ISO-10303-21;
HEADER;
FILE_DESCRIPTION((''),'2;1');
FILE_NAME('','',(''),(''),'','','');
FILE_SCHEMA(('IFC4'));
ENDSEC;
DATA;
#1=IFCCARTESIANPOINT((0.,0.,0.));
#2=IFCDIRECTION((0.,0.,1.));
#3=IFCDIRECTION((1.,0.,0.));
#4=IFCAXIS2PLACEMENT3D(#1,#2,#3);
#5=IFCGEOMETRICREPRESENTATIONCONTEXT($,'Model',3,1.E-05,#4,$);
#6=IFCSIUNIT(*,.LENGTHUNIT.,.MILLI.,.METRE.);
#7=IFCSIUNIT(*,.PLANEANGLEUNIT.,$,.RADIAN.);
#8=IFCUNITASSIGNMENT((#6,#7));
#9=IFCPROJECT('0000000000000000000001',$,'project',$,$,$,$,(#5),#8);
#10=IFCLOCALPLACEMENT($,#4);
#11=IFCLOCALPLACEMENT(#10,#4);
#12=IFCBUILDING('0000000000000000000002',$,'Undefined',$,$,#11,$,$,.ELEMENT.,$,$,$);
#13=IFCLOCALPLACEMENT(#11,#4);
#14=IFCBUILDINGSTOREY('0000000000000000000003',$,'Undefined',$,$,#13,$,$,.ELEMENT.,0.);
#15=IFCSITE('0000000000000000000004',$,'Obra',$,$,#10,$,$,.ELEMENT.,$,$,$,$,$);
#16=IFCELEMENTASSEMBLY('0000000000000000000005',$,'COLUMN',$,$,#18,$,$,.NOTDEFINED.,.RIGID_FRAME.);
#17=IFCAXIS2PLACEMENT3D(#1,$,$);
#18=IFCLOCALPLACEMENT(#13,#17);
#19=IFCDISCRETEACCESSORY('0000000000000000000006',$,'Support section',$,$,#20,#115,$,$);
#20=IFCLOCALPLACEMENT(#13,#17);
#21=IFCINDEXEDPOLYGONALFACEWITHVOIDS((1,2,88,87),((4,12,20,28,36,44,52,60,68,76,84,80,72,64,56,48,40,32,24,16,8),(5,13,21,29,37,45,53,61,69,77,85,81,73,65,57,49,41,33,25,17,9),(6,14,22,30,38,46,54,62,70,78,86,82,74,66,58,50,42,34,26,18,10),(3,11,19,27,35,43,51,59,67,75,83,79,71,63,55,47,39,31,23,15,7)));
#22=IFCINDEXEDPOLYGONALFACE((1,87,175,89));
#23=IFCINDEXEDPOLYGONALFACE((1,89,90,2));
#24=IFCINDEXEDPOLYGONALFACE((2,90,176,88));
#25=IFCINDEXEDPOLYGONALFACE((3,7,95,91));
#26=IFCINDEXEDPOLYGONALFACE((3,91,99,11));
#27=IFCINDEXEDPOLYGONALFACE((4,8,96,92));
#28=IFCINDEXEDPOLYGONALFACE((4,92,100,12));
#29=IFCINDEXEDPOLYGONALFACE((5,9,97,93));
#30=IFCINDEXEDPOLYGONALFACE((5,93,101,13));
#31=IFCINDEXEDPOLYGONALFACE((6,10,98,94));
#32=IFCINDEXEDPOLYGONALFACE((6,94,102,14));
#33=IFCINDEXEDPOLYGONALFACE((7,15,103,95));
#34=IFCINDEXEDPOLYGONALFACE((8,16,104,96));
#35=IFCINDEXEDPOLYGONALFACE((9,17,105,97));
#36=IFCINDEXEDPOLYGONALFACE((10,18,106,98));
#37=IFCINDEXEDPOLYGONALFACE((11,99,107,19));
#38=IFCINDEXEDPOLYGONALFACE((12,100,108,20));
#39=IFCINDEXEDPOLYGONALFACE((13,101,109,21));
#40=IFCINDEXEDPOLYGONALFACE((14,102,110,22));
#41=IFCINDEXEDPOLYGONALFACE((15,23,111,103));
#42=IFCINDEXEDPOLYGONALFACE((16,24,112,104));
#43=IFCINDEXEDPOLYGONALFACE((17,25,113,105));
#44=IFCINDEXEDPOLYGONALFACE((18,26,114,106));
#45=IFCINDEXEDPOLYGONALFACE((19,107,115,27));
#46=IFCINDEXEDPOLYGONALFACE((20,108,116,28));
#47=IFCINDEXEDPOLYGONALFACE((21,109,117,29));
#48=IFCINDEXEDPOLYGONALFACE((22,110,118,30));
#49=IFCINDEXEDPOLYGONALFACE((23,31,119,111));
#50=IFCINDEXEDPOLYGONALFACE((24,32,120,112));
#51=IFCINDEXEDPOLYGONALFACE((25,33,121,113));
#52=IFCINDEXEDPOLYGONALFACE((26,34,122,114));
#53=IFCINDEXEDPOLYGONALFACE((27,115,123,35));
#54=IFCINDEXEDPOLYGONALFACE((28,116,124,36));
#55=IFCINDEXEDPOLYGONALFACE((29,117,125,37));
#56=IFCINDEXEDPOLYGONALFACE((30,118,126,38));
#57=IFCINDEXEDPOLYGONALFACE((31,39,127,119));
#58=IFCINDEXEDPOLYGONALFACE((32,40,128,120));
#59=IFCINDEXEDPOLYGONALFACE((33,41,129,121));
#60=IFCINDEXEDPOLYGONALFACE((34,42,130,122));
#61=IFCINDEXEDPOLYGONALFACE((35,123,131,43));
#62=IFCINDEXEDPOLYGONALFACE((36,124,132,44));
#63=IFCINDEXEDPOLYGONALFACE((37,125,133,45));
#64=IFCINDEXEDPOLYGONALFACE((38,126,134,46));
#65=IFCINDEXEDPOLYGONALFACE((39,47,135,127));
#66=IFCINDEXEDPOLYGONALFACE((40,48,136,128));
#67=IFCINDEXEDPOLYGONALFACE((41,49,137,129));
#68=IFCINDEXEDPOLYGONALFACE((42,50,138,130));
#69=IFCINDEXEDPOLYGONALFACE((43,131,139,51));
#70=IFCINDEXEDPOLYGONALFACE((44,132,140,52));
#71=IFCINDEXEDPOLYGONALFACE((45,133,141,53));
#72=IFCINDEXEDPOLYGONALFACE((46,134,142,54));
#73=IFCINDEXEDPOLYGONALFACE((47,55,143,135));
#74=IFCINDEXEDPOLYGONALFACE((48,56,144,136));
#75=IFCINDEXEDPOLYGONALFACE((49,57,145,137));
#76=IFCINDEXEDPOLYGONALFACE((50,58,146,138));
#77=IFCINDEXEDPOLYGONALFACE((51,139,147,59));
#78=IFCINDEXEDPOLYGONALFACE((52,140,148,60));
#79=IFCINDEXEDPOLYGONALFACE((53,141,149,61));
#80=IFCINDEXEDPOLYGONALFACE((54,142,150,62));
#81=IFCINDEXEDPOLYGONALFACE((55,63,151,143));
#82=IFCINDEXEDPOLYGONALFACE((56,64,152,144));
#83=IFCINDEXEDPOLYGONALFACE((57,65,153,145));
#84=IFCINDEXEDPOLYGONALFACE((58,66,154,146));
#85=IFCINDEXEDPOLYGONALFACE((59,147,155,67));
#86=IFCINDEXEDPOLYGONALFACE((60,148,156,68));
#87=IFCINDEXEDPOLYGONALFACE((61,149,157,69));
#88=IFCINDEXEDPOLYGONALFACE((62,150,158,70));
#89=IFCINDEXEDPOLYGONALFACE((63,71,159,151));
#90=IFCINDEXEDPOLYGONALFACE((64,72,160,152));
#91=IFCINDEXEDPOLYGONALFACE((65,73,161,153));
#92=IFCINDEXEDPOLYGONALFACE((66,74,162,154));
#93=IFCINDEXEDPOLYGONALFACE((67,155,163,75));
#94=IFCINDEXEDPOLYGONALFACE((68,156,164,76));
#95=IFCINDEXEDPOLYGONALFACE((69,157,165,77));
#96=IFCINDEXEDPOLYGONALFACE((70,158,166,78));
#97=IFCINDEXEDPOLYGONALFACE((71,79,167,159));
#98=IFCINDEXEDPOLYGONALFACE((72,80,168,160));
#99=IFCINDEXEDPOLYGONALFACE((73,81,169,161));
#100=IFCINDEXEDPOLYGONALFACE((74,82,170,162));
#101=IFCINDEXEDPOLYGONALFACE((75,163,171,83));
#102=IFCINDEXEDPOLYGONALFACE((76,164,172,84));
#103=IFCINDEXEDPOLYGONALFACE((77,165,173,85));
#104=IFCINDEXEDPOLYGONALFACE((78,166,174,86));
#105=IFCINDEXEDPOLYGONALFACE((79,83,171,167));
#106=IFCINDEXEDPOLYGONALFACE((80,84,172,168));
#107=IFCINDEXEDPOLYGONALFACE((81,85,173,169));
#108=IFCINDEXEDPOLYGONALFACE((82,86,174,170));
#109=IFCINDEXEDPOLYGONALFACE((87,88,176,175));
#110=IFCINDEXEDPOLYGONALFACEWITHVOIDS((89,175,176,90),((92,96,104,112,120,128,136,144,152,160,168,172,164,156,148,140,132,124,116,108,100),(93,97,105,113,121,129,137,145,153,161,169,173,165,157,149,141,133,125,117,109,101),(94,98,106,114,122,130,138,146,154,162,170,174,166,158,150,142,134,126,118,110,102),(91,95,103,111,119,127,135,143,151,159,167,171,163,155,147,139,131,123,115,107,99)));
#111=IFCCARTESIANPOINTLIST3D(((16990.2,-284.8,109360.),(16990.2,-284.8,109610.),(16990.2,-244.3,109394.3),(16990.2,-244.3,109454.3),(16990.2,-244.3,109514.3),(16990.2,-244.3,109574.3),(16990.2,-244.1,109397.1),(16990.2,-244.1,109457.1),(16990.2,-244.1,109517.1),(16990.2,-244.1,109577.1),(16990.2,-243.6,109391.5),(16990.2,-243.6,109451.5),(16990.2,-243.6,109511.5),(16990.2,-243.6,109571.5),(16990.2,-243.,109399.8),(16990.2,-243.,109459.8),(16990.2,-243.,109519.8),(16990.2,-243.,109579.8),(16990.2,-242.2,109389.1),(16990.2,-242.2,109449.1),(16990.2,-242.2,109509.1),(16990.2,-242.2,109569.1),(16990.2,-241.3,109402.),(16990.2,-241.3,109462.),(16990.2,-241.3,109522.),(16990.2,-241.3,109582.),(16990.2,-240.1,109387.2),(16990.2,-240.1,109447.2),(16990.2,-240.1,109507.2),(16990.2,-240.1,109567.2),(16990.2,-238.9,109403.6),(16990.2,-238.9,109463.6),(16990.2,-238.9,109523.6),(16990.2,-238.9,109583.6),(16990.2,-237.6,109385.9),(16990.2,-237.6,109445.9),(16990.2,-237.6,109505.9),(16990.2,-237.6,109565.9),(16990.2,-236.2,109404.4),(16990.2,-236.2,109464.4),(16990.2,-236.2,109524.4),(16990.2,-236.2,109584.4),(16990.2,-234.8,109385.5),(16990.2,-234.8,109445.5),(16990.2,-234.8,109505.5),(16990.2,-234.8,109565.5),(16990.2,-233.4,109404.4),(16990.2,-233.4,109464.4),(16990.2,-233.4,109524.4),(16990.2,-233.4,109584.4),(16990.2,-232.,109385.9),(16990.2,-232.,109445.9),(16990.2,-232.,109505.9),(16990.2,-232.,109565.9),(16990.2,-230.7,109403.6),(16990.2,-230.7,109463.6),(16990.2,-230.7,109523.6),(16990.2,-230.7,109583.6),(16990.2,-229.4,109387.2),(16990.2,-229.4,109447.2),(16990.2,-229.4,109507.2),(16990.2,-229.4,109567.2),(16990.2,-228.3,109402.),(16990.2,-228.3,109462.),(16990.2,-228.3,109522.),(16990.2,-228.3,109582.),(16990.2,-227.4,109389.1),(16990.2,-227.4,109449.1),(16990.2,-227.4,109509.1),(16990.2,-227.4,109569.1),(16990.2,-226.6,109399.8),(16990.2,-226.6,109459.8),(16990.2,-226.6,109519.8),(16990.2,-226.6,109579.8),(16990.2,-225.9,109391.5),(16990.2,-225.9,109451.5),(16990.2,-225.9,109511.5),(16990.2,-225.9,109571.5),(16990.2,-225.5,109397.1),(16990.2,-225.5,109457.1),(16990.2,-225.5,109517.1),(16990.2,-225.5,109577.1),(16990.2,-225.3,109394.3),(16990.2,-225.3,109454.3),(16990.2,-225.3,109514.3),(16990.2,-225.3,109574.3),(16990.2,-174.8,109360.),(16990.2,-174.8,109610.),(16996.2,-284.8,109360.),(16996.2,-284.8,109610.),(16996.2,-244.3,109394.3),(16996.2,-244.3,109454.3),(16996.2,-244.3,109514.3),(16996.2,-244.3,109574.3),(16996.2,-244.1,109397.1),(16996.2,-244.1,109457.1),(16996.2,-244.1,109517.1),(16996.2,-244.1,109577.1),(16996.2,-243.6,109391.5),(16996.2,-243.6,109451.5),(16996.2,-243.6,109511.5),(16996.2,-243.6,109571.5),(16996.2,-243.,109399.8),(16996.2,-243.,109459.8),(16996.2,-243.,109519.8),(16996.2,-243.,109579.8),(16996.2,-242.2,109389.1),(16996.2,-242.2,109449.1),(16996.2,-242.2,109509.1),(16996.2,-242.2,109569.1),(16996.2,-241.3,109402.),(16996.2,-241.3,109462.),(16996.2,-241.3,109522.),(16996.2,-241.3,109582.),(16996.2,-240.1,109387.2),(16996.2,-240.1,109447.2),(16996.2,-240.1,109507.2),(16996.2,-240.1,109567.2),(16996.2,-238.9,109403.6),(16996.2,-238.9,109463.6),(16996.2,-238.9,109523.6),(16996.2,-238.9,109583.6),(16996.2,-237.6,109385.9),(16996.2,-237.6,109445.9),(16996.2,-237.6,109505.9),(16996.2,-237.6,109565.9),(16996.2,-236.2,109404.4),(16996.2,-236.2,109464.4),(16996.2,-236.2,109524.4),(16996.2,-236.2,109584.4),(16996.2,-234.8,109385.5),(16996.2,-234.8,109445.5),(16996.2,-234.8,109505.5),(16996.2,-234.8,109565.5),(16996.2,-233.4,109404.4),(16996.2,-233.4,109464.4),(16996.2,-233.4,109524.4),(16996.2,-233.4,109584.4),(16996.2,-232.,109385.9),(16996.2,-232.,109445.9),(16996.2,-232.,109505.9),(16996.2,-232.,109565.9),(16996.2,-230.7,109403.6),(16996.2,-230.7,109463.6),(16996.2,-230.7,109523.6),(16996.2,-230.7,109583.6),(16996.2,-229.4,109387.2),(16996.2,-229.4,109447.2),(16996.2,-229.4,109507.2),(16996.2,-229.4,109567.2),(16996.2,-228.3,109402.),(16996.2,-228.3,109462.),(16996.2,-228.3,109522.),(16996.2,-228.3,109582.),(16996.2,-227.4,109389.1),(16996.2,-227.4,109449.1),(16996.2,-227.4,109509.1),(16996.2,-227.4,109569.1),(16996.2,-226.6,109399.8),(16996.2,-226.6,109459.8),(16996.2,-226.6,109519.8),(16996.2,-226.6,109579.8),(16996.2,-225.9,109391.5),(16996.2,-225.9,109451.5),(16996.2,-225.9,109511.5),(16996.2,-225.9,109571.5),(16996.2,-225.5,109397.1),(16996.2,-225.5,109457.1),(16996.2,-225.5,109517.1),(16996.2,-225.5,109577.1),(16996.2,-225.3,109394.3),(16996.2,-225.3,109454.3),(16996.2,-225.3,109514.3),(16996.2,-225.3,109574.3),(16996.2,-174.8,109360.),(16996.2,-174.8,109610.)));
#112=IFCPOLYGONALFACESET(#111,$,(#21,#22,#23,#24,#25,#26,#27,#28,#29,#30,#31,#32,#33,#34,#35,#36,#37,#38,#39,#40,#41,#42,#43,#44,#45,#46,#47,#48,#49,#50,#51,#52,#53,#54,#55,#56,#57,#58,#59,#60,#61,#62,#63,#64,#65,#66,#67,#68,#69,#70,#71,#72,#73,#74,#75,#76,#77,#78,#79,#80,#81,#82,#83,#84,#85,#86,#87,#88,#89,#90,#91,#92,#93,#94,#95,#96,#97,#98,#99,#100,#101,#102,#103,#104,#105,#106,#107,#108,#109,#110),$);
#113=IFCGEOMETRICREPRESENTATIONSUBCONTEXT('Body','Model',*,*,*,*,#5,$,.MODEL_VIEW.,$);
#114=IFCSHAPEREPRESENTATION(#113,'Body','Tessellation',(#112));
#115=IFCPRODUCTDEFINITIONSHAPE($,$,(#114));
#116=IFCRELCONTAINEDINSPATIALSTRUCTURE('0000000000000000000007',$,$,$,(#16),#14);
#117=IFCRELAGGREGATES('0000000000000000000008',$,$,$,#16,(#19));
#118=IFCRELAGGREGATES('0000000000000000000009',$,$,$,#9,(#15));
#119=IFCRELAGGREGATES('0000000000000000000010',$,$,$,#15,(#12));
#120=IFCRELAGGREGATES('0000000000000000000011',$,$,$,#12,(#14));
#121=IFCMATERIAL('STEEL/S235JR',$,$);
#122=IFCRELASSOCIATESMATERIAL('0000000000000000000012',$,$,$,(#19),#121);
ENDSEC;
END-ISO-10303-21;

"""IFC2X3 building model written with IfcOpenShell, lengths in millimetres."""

from ifc_helpers import new_model, si_unit, frame, origin_with_axes, origin_2d_with_axis, place, context, subcontext, project, spatial, rectangle, circle, extrude, source, transform, mapped, material, element, aggregate, save


model = new_model("IFC2X3")

# Units and contexts
model_context = context("Model", 3, precision=1e-05, world=origin_with_axes())
body_context = subcontext(model_context, "Body", "Model", "MODEL_VIEW")
ifc_project = project(units=[si_unit("LENGTHUNIT", "METRE", prefix="MILLI"), si_unit("PLANEANGLEUNIT", "RADIAN")], contexts=[model_context])

# Site, building, storey
site_placement = place(None, origin_with_axes())
site = spatial("IfcSite", under=ifc_project, at=site_placement, Name="Obra", CompositionType="ELEMENT")
building_placement = place(site_placement, origin_with_axes())
building = spatial("IfcBuilding", under=site, at=building_placement, Name="Undefined", CompositionType="ELEMENT")
storey_placement = place(building_placement, origin_with_axes())
storey = spatial("IfcBuildingStorey", under=building, at=storey_placement, Name="Undefined", CompositionType="ELEMENT", Elevation=0.0)

# Element assembly, discrete accessory, opening
assembly_1_placement = place(storey_placement, origin_with_axes())
assembly_1 = element("IfcElementAssembly", 1, at=assembly_1_placement, inside=storey, Name="COLUMN", AssemblyPlace="NOTDEFINED", PredefinedType="RIGID_FRAME")
ifc_material_1 = material(Name="STEEL/S235JR")
shared_shape_1 = source(origin_with_axes(), body_context, "Body", "SweptSolid", [
    extrude(circle(Radius=9.5, at=origin_2d_with_axis()), frame((0.0, -9.8, 0.0), z_axis=(0.0, 1.0, 0.0), x_axis=(1.0, 0.0, 0.0)), (0.0, 0.0, 1.0), 6.2),
])
discrete_accessory_1_placement = place(assembly_1_placement, frame((16993.2, -229.8, 109360.0), z_axis=(0.0, 0.0, 1.0), x_axis=(0.0, 1.0, 0.0)))
discrete_accessory_1 = element("IfcDiscreteAccessory", 2, at=discrete_accessory_1_placement, material=ifc_material_1, Name="Support section", context=body_context, shape_type="SweptSolid", body=[
    extrude(rectangle(XDim=6.0, YDim=110.0, at=origin_2d_with_axis()), frame((0.0, 0.0, 250.0), z_axis=(0.0, 0.0, -1.0), x_axis=(0.0, 1.0, 0.0)), (0.0, 0.0, 1.0), 250.0),
])
opening_1_placement = place(assembly_1_placement, frame((17000.0, -184.8, 109650.0), z_axis=(0.0, -1.0, 0.0), x_axis=(0.0, 0.0, -1.0)))
element("IfcOpeningElement", 3, at=opening_1_placement, cuts=discrete_accessory_1, ObjectType="Opening", context=body_context, shape_type="MappedRepresentation", body=[
    mapped(shared_shape_1, transform((75.0, 0.0, 50.0))),
    mapped(shared_shape_1, transform((135.0, 0.0, 50.0))),
    mapped(shared_shape_1, transform((195.0, 0.0, 50.0))),
    mapped(shared_shape_1, transform((255.0, 0.0, 50.0))),
])
aggregate(assembly_1, [discrete_accessory_1])

save(model, "model.ifc")
